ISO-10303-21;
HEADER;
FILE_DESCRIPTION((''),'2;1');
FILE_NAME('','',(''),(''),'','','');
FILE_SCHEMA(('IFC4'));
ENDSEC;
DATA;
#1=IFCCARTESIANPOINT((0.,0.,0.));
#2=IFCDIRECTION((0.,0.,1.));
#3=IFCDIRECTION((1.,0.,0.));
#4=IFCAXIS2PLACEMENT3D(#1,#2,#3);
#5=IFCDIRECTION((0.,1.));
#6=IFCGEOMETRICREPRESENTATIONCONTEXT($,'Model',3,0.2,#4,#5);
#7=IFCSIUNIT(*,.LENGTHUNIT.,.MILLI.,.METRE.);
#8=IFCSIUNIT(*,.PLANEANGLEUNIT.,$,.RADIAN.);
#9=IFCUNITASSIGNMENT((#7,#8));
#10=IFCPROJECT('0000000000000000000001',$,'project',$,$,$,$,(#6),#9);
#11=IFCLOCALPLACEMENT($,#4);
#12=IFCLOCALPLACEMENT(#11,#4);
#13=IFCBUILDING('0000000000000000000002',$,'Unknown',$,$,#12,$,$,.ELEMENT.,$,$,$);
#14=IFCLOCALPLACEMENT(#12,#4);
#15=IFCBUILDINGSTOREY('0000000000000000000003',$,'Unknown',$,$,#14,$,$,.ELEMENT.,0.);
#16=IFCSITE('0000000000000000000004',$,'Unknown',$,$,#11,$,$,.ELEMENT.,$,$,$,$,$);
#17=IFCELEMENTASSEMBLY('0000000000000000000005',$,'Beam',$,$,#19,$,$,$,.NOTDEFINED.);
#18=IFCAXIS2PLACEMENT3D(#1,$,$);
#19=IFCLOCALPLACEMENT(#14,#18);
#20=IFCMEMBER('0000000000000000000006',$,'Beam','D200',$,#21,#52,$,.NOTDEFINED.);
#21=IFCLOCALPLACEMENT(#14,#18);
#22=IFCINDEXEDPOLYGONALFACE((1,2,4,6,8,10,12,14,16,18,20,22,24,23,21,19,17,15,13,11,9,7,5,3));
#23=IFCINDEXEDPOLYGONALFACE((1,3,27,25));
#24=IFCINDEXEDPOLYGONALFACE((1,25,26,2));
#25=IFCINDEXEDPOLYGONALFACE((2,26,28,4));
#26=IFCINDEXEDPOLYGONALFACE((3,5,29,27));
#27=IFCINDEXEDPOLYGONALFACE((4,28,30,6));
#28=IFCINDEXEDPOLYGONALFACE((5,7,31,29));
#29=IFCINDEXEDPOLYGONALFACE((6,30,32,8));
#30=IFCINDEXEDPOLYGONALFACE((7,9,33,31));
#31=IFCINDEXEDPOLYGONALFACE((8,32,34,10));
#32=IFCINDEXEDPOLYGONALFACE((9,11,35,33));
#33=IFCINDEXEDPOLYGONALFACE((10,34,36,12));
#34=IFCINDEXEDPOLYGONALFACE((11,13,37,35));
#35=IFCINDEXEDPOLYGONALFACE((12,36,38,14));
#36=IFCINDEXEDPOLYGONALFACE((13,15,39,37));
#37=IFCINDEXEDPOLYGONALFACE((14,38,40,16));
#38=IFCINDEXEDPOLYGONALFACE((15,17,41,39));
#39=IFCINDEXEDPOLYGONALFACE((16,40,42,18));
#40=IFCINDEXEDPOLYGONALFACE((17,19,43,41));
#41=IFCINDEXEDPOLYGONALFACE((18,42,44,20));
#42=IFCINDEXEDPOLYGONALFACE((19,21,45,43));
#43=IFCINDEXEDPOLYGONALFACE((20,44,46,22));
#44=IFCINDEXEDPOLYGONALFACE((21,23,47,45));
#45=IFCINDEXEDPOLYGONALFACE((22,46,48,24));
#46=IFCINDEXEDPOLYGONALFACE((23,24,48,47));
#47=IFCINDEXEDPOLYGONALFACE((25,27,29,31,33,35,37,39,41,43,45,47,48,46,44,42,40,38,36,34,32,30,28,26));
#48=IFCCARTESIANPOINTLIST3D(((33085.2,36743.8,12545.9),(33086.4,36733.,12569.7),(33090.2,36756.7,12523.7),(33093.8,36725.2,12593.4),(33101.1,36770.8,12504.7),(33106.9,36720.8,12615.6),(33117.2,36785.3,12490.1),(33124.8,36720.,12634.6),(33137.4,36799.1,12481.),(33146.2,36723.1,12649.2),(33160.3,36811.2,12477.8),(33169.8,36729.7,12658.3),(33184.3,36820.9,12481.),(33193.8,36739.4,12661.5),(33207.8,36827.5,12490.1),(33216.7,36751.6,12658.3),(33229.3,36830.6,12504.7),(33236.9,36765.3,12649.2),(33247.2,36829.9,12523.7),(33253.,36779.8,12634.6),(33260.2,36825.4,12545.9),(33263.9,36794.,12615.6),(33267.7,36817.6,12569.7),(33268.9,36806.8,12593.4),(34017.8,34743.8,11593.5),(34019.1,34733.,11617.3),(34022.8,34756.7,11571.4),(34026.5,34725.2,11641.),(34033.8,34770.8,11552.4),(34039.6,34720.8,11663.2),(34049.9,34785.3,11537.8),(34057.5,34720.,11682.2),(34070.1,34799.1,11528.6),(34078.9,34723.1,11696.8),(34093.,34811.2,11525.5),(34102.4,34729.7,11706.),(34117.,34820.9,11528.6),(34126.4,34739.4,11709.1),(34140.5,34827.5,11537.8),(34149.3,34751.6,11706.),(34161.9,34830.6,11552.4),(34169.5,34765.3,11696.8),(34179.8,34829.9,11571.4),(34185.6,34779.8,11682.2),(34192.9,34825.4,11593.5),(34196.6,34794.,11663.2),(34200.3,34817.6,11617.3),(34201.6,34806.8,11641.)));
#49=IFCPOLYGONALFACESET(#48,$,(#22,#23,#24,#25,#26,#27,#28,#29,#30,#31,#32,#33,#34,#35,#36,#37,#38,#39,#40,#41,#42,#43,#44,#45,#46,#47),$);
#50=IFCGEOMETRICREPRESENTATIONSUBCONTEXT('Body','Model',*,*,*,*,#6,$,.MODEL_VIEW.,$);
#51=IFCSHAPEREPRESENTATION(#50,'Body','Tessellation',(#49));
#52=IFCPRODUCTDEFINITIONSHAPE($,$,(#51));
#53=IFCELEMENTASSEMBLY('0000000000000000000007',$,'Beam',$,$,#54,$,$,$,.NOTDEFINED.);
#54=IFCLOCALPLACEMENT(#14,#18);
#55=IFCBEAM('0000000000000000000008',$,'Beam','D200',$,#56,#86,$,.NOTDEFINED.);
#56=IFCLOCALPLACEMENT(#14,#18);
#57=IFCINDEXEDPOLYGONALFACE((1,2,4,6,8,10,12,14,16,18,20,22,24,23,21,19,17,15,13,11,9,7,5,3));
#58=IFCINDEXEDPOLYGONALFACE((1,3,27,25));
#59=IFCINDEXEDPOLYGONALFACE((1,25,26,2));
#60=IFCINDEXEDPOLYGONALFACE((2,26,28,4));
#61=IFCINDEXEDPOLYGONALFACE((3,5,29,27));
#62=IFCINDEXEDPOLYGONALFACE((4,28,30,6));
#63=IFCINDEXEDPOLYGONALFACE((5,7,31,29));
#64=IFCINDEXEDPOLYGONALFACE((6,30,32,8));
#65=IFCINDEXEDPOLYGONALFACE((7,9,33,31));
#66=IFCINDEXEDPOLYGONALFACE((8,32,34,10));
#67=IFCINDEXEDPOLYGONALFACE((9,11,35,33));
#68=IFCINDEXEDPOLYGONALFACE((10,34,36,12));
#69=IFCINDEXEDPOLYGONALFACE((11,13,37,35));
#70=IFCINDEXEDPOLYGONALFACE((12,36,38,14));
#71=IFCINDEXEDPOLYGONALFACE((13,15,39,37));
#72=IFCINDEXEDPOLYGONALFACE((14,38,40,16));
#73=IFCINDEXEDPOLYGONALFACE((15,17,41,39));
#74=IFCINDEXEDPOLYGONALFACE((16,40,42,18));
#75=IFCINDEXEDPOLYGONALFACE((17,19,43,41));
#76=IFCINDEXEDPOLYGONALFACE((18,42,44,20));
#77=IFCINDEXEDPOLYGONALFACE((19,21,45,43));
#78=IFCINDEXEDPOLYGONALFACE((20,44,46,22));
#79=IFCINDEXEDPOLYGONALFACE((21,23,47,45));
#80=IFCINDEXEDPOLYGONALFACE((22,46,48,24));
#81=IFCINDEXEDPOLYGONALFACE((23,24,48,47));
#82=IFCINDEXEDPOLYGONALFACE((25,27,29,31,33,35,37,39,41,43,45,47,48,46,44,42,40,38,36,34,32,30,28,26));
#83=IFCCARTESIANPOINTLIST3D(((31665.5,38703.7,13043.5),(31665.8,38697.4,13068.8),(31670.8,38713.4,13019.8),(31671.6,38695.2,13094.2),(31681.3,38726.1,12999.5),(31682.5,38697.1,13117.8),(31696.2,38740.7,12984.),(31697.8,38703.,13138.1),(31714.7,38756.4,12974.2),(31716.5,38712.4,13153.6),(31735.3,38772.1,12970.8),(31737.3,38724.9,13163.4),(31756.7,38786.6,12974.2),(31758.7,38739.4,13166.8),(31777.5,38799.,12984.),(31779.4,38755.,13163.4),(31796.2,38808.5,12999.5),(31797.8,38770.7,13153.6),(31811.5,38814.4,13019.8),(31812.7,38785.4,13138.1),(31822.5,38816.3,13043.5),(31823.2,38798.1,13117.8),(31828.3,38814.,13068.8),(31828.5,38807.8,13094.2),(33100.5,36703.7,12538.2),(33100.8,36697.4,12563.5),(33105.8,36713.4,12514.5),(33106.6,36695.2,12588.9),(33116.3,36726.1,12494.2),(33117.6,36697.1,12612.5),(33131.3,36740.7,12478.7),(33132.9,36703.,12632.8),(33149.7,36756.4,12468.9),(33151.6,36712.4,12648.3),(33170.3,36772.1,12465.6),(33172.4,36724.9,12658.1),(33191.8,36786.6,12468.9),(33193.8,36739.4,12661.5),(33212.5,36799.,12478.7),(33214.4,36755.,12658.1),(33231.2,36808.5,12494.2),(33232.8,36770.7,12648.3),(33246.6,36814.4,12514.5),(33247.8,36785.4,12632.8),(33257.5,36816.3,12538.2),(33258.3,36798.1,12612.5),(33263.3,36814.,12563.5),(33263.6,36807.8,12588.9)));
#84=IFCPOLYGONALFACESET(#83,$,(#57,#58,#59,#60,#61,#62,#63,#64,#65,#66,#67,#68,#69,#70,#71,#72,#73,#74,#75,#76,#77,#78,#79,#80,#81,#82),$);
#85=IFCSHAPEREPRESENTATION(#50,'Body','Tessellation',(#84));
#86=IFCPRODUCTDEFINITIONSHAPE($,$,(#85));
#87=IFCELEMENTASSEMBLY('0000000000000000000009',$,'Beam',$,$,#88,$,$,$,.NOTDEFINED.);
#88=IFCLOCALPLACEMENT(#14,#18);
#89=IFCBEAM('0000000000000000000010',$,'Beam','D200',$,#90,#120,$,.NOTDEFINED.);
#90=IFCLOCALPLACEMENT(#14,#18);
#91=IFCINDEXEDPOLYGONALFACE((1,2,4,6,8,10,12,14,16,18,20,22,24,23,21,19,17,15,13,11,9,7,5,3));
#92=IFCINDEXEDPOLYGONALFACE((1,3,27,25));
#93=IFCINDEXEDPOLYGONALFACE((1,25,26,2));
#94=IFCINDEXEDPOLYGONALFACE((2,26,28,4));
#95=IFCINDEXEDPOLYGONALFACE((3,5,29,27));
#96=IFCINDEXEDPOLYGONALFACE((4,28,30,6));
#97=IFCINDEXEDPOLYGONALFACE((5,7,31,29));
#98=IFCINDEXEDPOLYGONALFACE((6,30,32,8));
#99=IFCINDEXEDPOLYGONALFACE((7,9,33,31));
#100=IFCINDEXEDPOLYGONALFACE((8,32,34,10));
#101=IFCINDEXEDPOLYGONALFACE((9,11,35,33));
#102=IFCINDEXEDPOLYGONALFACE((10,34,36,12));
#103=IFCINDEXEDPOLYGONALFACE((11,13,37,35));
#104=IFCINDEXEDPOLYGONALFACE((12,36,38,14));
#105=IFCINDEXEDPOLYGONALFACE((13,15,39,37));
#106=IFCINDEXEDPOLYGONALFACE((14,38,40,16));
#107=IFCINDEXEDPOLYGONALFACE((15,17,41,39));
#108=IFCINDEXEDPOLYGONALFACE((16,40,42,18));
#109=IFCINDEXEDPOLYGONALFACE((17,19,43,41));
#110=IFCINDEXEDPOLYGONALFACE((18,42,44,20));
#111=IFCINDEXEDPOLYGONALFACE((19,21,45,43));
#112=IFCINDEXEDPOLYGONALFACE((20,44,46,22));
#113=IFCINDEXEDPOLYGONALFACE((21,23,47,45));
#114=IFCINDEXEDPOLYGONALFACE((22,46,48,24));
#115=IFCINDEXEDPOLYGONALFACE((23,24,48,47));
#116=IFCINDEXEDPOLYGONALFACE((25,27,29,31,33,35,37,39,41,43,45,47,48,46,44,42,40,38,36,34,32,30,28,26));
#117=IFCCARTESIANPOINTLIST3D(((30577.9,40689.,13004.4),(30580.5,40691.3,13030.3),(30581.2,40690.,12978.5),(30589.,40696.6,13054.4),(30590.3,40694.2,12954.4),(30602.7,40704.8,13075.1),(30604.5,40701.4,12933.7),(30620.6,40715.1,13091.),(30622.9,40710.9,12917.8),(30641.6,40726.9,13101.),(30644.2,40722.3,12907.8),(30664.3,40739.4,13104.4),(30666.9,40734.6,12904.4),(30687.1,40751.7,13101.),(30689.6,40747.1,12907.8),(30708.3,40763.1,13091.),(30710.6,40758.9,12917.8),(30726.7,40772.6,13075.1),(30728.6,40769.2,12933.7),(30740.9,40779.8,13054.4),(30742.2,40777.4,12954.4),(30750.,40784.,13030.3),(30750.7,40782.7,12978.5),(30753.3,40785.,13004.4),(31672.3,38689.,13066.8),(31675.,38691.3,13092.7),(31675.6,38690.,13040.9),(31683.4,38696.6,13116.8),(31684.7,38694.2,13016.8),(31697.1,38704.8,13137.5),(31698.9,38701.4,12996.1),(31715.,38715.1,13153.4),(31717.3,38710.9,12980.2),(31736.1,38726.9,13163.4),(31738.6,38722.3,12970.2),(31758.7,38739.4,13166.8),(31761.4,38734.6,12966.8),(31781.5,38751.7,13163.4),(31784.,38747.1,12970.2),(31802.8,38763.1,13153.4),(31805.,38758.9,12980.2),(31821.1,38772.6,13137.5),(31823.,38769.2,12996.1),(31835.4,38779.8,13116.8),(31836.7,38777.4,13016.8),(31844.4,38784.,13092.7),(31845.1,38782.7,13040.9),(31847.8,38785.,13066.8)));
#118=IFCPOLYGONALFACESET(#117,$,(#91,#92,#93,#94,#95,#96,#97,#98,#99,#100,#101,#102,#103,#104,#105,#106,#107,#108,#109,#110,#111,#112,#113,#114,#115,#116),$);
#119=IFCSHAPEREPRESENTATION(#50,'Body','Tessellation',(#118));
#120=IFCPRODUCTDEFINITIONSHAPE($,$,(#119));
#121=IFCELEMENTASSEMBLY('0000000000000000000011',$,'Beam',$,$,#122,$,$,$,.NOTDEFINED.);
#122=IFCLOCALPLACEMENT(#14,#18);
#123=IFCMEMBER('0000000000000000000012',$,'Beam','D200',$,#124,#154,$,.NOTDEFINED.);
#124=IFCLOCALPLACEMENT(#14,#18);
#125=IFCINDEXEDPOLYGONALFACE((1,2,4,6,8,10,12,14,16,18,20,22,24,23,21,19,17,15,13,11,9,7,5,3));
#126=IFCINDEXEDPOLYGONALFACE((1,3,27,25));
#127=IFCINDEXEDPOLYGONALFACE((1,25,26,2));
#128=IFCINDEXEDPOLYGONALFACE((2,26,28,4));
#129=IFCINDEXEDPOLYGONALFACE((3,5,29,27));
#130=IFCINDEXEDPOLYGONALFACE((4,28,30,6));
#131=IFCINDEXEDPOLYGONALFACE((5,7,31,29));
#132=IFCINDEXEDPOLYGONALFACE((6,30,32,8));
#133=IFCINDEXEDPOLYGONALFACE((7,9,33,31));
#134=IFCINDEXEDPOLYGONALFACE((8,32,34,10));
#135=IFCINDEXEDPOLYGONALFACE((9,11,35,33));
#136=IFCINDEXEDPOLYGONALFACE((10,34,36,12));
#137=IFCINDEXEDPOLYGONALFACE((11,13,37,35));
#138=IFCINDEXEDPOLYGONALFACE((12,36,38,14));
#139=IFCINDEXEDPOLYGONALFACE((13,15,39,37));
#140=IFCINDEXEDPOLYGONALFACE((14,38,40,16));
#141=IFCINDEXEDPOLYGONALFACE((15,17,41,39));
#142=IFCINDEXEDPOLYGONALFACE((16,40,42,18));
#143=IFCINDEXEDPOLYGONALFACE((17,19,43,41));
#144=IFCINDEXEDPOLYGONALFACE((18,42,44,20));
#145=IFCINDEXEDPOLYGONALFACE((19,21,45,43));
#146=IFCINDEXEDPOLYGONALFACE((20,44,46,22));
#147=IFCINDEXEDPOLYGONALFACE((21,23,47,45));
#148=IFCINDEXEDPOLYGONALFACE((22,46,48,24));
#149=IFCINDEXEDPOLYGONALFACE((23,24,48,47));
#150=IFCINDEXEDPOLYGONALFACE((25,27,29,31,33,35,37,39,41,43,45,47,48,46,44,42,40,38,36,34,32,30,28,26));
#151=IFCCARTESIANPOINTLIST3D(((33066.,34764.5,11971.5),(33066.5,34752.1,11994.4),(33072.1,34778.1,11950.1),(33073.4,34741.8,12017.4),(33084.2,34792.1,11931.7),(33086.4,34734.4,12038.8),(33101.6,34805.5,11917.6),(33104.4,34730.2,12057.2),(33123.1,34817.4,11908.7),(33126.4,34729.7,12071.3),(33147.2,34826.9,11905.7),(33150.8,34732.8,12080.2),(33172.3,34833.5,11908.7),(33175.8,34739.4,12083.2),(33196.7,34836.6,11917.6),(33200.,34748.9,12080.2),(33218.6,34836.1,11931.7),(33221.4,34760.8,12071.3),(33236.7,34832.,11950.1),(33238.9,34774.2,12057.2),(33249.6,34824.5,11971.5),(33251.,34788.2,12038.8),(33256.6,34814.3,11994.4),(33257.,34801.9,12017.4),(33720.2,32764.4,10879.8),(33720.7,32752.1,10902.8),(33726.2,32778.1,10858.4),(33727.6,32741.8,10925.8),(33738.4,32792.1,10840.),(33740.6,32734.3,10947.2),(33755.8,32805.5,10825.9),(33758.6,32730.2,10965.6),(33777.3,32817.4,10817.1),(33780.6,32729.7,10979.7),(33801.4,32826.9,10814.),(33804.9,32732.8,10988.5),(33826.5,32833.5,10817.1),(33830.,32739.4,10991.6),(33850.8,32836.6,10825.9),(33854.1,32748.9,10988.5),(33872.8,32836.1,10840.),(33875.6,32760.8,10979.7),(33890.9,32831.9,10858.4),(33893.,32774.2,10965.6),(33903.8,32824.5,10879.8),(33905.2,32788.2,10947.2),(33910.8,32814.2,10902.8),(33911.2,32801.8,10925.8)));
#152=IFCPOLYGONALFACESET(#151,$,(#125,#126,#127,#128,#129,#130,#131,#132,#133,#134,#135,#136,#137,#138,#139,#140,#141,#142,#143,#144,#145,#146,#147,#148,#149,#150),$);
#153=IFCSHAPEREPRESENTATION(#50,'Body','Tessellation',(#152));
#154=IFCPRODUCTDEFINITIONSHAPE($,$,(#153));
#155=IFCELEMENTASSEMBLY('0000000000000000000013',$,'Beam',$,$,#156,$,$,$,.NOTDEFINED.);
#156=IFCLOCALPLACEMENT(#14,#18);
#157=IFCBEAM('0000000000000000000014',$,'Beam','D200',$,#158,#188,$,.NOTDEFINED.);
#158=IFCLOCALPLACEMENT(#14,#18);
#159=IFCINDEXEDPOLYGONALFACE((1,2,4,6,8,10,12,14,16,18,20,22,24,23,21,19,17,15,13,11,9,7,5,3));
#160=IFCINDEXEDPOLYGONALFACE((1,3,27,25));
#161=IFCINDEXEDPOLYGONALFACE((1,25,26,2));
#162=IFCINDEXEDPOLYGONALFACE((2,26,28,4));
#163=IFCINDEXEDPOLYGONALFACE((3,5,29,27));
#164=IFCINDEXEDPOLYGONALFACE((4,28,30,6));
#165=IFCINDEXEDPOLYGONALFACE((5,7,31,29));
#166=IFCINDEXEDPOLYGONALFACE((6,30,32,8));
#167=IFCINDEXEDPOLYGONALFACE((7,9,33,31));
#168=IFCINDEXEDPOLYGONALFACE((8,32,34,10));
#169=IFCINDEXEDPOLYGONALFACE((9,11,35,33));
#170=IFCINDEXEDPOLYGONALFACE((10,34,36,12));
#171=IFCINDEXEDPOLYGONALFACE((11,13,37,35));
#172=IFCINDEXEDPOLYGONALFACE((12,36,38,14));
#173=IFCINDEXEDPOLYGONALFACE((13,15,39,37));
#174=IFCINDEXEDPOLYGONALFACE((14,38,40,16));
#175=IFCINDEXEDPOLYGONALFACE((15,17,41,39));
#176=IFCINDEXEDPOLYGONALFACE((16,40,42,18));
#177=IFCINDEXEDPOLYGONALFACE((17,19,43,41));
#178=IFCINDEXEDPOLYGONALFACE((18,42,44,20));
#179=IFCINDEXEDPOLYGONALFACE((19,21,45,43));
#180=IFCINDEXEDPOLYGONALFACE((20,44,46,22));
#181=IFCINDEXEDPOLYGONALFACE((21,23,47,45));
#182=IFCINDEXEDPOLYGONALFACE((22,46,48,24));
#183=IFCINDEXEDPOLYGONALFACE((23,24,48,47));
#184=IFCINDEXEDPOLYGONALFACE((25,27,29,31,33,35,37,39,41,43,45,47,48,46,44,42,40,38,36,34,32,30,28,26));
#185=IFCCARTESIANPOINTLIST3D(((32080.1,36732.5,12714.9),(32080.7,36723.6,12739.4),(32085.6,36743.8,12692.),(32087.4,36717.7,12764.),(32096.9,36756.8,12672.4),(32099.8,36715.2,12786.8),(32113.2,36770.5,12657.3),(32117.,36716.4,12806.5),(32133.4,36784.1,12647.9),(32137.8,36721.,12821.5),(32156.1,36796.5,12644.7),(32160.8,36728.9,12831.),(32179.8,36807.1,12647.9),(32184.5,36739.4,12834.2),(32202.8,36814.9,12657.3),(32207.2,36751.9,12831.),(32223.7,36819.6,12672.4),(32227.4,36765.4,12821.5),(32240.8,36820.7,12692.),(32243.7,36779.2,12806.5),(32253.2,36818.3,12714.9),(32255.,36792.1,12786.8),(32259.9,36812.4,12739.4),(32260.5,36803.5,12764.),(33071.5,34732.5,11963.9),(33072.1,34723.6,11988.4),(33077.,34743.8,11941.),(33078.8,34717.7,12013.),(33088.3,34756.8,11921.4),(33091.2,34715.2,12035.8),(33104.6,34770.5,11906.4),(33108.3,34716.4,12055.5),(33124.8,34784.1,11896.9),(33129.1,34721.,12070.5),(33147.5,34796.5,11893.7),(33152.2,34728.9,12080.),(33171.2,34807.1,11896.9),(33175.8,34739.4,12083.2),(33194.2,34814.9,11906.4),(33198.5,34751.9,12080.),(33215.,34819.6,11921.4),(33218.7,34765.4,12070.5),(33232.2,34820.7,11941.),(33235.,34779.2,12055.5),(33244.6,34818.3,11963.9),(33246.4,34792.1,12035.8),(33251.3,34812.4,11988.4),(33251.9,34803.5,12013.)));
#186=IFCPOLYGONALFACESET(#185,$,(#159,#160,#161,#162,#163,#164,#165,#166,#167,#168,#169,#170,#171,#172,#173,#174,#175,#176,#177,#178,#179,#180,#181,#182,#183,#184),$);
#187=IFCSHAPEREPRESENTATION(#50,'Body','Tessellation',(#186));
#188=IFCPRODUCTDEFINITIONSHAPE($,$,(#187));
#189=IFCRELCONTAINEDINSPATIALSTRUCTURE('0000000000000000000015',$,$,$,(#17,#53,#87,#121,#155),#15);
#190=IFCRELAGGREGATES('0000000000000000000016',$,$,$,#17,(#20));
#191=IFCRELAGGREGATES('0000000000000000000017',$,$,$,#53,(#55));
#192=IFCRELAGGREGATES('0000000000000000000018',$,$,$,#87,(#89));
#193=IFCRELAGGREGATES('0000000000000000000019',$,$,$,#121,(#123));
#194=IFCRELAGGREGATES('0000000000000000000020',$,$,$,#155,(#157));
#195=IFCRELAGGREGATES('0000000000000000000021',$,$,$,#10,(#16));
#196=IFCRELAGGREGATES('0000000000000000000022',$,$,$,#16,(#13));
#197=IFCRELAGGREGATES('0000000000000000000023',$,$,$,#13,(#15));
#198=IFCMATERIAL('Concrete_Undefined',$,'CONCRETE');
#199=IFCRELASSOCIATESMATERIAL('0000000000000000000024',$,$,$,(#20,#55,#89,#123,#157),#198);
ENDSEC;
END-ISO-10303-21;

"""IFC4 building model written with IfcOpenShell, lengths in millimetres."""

from ifc_helpers import new_model, si_unit, direction, frame, origin_with_axes, place, context, subcontext, project, spatial, line, indexed_curve, outline, extrude, material, element, aggregate, save


model = new_model("IFC4")

# Units and contexts
model_context = context("Model", 3, precision=0.2, world=origin_with_axes(), true_north=direction((0.0, 1.0)))
body_context = subcontext(model_context, "Body", "Model", "MODEL_VIEW")
ifc_project = project(units=[si_unit("LENGTHUNIT", "METRE", prefix="MILLI"), si_unit("PLANEANGLEUNIT", "RADIAN")], contexts=[model_context])

# Site, building, storey
site_placement = place(None, origin_with_axes())
site = spatial("IfcSite", under=ifc_project, at=site_placement, Name="Unknown", CompositionType="ELEMENT")
building_placement = place(site_placement, origin_with_axes())
building = spatial("IfcBuilding", under=site, at=building_placement, Name="Unknown", CompositionType="ELEMENT")
storey_placement = place(building_placement, origin_with_axes())
storey = spatial("IfcBuildingStorey", under=building, at=storey_placement, Name="Unknown", CompositionType="ELEMENT", Elevation=0.0)

# Shared definitions
ifc_material = material(Name="Concrete_Undefined", Category="CONCRETE")

# Element assembly, member
assembly_1_placement = place(storey_placement, frame((33177.0, 36775.3, 12569.7), z_axis=(-0.9063, -0.422635, 0.0), x_axis=(0.388041, -0.832115, -0.396244)))
assembly_1 = element("IfcElementAssembly", 1, at=assembly_1_placement, inside=storey, Name="Beam", PredefinedType="NOTDEFINED")
member_1_placement = place(assembly_1_placement, origin_with_axes())
member_1 = element("IfcMember", 2, at=member_1_placement, material=ifc_material, Name="Beam", Description="D200", PredefinedType="NOTDEFINED", context=body_context, shape_type="SolidModel", body=[
    extrude(outline(indexed_curve([(100.0, 0.0), (96.6, 25.9), (86.6, 50.0), (70.7, 70.7), (50.0, 86.6), (25.9, 96.6), (0.0, 100.0), (-25.9, 96.6), (-50.0, 86.6), (-70.7, 70.7), (-86.6, 50.0), (-96.6, 25.9), (-100.0, 0.0), (-96.6, -25.9), (-86.6, -50.0), (-70.7, -70.7), (-50.0, -86.6), (-25.9, -96.6), (0.0, -100.0), (25.9, -96.6), (50.0, -86.6), (70.7, -70.7), (86.6, -50.0), (96.6, -25.9)], segments=[line(1, 2, 3, 4, 5, 6, 7, 8, 9, 10, 11, 12, 13, 14, 15, 16, 17, 18, 19, 20, 21, 22, 23, 24, 1)])), frame((0.0, 0.0, 0.0), z_axis=(-1.0, 0.0, 0.0), x_axis=(0.0, 0.0, 1.0)), (0.0, 0.0, -1.0), 2403.5),
])
aggregate(assembly_1, [member_1])

# Element assemblies, beams
assembly_2_placement = place(storey_placement, frame((31747.0, 38755.7, 13068.8), z_axis=(-0.812486, -0.58298, 0.0), x_axis=(0.571073, -0.795891, -0.201079)))
assembly_2 = element("IfcElementAssembly", 3, at=assembly_2_placement, inside=storey, Name="Beam", PredefinedType="NOTDEFINED")
beam_1_placement = place(assembly_2_placement, origin_with_axes())
beam_1 = element("IfcBeam", 4, at=beam_1_placement, material=ifc_material, Name="Beam", Description="D200", PredefinedType="NOTDEFINED", context=body_context, shape_type="SolidModel", body=[
    extrude(outline(indexed_curve([(100.0, 0.0), (96.6, 25.9), (86.6, 50.0), (70.7, 70.7), (50.0, 86.6), (25.9, 96.6), (0.0, 100.0), (-25.9, 96.6), (-50.0, 86.6), (-70.7, 70.7), (-86.6, 50.0), (-96.6, 25.9), (-100.0, 0.0), (-96.6, -25.9), (-86.6, -50.0), (-70.7, -70.7), (-50.0, -86.6), (-25.9, -96.6), (0.0, -100.0), (25.9, -96.6), (50.0, -86.6), (70.7, -70.7), (86.6, -50.0), (96.6, -25.9)], segments=[line(1, 2, 3, 4, 5, 6, 7, 8, 9, 10, 11, 12, 13, 14, 15, 16, 17, 18, 19, 20, 21, 22, 23, 24, 1)])), frame((0.0, 0.0, 0.0), z_axis=(-1.0, 0.0, 0.0), x_axis=(0.0, 0.0, 1.0)), (0.0, 0.0, -1.0), 2512.9),
])
aggregate(assembly_2, [beam_1])
assembly_3_placement = place(storey_placement, frame((30665.6, 40737.0, 13004.4), z_axis=(-0.877246, -0.480041, 0.0), x_axis=(0.479862, -0.876917, 0.027357)))
assembly_3 = element("IfcElementAssembly", 5, at=assembly_3_placement, inside=storey, Name="Beam", PredefinedType="NOTDEFINED")
beam_2_placement = place(assembly_3_placement, origin_with_axes())
beam_2 = element("IfcBeam", 6, at=beam_2_placement, material=ifc_material, Name="Beam", Description="D200", PredefinedType="NOTDEFINED", context=body_context, shape_type="SolidModel", body=[
    extrude(outline(indexed_curve([(100.0, 0.0), (96.6, 25.9), (86.6, 50.0), (70.7, 70.7), (50.0, 86.6), (25.9, 96.6), (0.0, 100.0), (-25.9, 96.6), (-50.0, 86.6), (-70.7, 70.7), (-86.6, 50.0), (-96.6, 25.9), (-100.0, 0.0), (-96.6, -25.9), (-86.6, -50.0), (-70.7, -70.7), (-50.0, -86.6), (-25.9, -96.6), (0.0, -100.0), (25.9, -96.6), (50.0, -86.6), (70.7, -70.7), (86.6, -50.0), (96.6, -25.9)], segments=[line(1, 2, 3, 4, 5, 6, 7, 8, 9, 10, 11, 12, 13, 14, 15, 16, 17, 18, 19, 20, 21, 22, 23, 24, 1)])), frame((0.0, 0.0, 0.0), z_axis=(-1.0, 0.0, 0.0), x_axis=(0.0, 0.0, 1.0)), (0.0, 0.0, -1.0), 2280.7),
])
aggregate(assembly_3, [beam_2])

# Element assembly, member
assembly_4_placement = place(storey_placement, frame((33161.5, 34783.2, 11994.4), z_axis=(-0.95045, -0.310878, 0.0), x_axis=(0.275955, -0.843679, -0.460494)))
assembly_4 = element("IfcElementAssembly", 7, at=assembly_4_placement, inside=storey, Name="Beam", PredefinedType="NOTDEFINED")
member_2_placement = place(assembly_4_placement, origin_with_axes())
member_2 = element("IfcMember", 8, at=member_2_placement, material=ifc_material, Name="Beam", Description="D200", PredefinedType="NOTDEFINED", context=body_context, shape_type="SolidModel", body=[
    extrude(outline(indexed_curve([(100.0, 0.0), (96.6, 25.9), (86.6, 50.0), (70.7, 70.7), (50.0, 86.6), (25.9, 96.6), (0.0, 100.0), (-25.9, 96.6), (-50.0, 86.6), (-70.7, 70.7), (-86.6, 50.0), (-96.6, 25.9), (-100.0, 0.0), (-96.6, -25.9), (-86.6, -50.0), (-70.7, -70.7), (-50.0, -86.6), (-25.9, -96.6), (0.0, -100.0), (25.9, -96.6), (50.0, -86.6), (70.7, -70.7), (86.6, -50.0), (96.6, -25.9)], segments=[line(1, 2, 3, 4, 5, 6, 7, 8, 9, 10, 11, 12, 13, 14, 15, 16, 17, 18, 19, 20, 21, 22, 23, 24, 1)])), frame((0.0, 0.0, 0.0), z_axis=(-1.0, 0.0, 0.0), x_axis=(0.0, 0.0, 1.0)), (0.0, 0.0, -1.0), 2370.6),
])
aggregate(assembly_4, [member_2])

# Element assembly, beam
assembly_5_placement = place(storey_placement, frame((32170.3, 36768.0, 12739.4), z_axis=(-0.895968, -0.444118, 0.0), x_axis=(0.420934, -0.849197, -0.318872)))
assembly_5 = element("IfcElementAssembly", 9, at=assembly_5_placement, inside=storey, Name="Beam", PredefinedType="NOTDEFINED")
beam_3_placement = place(assembly_5_placement, origin_with_axes())
beam_3 = element("IfcBeam", 10, at=beam_3_placement, material=ifc_material, Name="Beam", Description="D200", PredefinedType="NOTDEFINED", context=body_context, shape_type="SolidModel", body=[
    extrude(outline(indexed_curve([(100.0, 0.0), (96.6, 25.9), (86.6, 50.0), (70.7, 70.7), (50.0, 86.6), (25.9, 96.6), (0.0, 100.0), (-25.9, 96.6), (-50.0, 86.6), (-70.7, 70.7), (-86.6, 50.0), (-96.6, 25.9), (-100.0, 0.0), (-96.6, -25.9), (-86.6, -50.0), (-70.7, -70.7), (-50.0, -86.6), (-25.9, -96.6), (0.0, -100.0), (25.9, -96.6), (50.0, -86.6), (70.7, -70.7), (86.6, -50.0), (96.6, -25.9)], segments=[line(1, 2, 3, 4, 5, 6, 7, 8, 9, 10, 11, 12, 13, 14, 15, 16, 17, 18, 19, 20, 21, 22, 23, 24, 1)])), frame((0.0, 0.0, 0.0), z_axis=(-1.0, 0.0, 0.0), x_axis=(0.0, 0.0, 1.0)), (0.0, 0.0, -1.0), 2355.2),
])
aggregate(assembly_5, [beam_3])

save(model, "model.ifc")
